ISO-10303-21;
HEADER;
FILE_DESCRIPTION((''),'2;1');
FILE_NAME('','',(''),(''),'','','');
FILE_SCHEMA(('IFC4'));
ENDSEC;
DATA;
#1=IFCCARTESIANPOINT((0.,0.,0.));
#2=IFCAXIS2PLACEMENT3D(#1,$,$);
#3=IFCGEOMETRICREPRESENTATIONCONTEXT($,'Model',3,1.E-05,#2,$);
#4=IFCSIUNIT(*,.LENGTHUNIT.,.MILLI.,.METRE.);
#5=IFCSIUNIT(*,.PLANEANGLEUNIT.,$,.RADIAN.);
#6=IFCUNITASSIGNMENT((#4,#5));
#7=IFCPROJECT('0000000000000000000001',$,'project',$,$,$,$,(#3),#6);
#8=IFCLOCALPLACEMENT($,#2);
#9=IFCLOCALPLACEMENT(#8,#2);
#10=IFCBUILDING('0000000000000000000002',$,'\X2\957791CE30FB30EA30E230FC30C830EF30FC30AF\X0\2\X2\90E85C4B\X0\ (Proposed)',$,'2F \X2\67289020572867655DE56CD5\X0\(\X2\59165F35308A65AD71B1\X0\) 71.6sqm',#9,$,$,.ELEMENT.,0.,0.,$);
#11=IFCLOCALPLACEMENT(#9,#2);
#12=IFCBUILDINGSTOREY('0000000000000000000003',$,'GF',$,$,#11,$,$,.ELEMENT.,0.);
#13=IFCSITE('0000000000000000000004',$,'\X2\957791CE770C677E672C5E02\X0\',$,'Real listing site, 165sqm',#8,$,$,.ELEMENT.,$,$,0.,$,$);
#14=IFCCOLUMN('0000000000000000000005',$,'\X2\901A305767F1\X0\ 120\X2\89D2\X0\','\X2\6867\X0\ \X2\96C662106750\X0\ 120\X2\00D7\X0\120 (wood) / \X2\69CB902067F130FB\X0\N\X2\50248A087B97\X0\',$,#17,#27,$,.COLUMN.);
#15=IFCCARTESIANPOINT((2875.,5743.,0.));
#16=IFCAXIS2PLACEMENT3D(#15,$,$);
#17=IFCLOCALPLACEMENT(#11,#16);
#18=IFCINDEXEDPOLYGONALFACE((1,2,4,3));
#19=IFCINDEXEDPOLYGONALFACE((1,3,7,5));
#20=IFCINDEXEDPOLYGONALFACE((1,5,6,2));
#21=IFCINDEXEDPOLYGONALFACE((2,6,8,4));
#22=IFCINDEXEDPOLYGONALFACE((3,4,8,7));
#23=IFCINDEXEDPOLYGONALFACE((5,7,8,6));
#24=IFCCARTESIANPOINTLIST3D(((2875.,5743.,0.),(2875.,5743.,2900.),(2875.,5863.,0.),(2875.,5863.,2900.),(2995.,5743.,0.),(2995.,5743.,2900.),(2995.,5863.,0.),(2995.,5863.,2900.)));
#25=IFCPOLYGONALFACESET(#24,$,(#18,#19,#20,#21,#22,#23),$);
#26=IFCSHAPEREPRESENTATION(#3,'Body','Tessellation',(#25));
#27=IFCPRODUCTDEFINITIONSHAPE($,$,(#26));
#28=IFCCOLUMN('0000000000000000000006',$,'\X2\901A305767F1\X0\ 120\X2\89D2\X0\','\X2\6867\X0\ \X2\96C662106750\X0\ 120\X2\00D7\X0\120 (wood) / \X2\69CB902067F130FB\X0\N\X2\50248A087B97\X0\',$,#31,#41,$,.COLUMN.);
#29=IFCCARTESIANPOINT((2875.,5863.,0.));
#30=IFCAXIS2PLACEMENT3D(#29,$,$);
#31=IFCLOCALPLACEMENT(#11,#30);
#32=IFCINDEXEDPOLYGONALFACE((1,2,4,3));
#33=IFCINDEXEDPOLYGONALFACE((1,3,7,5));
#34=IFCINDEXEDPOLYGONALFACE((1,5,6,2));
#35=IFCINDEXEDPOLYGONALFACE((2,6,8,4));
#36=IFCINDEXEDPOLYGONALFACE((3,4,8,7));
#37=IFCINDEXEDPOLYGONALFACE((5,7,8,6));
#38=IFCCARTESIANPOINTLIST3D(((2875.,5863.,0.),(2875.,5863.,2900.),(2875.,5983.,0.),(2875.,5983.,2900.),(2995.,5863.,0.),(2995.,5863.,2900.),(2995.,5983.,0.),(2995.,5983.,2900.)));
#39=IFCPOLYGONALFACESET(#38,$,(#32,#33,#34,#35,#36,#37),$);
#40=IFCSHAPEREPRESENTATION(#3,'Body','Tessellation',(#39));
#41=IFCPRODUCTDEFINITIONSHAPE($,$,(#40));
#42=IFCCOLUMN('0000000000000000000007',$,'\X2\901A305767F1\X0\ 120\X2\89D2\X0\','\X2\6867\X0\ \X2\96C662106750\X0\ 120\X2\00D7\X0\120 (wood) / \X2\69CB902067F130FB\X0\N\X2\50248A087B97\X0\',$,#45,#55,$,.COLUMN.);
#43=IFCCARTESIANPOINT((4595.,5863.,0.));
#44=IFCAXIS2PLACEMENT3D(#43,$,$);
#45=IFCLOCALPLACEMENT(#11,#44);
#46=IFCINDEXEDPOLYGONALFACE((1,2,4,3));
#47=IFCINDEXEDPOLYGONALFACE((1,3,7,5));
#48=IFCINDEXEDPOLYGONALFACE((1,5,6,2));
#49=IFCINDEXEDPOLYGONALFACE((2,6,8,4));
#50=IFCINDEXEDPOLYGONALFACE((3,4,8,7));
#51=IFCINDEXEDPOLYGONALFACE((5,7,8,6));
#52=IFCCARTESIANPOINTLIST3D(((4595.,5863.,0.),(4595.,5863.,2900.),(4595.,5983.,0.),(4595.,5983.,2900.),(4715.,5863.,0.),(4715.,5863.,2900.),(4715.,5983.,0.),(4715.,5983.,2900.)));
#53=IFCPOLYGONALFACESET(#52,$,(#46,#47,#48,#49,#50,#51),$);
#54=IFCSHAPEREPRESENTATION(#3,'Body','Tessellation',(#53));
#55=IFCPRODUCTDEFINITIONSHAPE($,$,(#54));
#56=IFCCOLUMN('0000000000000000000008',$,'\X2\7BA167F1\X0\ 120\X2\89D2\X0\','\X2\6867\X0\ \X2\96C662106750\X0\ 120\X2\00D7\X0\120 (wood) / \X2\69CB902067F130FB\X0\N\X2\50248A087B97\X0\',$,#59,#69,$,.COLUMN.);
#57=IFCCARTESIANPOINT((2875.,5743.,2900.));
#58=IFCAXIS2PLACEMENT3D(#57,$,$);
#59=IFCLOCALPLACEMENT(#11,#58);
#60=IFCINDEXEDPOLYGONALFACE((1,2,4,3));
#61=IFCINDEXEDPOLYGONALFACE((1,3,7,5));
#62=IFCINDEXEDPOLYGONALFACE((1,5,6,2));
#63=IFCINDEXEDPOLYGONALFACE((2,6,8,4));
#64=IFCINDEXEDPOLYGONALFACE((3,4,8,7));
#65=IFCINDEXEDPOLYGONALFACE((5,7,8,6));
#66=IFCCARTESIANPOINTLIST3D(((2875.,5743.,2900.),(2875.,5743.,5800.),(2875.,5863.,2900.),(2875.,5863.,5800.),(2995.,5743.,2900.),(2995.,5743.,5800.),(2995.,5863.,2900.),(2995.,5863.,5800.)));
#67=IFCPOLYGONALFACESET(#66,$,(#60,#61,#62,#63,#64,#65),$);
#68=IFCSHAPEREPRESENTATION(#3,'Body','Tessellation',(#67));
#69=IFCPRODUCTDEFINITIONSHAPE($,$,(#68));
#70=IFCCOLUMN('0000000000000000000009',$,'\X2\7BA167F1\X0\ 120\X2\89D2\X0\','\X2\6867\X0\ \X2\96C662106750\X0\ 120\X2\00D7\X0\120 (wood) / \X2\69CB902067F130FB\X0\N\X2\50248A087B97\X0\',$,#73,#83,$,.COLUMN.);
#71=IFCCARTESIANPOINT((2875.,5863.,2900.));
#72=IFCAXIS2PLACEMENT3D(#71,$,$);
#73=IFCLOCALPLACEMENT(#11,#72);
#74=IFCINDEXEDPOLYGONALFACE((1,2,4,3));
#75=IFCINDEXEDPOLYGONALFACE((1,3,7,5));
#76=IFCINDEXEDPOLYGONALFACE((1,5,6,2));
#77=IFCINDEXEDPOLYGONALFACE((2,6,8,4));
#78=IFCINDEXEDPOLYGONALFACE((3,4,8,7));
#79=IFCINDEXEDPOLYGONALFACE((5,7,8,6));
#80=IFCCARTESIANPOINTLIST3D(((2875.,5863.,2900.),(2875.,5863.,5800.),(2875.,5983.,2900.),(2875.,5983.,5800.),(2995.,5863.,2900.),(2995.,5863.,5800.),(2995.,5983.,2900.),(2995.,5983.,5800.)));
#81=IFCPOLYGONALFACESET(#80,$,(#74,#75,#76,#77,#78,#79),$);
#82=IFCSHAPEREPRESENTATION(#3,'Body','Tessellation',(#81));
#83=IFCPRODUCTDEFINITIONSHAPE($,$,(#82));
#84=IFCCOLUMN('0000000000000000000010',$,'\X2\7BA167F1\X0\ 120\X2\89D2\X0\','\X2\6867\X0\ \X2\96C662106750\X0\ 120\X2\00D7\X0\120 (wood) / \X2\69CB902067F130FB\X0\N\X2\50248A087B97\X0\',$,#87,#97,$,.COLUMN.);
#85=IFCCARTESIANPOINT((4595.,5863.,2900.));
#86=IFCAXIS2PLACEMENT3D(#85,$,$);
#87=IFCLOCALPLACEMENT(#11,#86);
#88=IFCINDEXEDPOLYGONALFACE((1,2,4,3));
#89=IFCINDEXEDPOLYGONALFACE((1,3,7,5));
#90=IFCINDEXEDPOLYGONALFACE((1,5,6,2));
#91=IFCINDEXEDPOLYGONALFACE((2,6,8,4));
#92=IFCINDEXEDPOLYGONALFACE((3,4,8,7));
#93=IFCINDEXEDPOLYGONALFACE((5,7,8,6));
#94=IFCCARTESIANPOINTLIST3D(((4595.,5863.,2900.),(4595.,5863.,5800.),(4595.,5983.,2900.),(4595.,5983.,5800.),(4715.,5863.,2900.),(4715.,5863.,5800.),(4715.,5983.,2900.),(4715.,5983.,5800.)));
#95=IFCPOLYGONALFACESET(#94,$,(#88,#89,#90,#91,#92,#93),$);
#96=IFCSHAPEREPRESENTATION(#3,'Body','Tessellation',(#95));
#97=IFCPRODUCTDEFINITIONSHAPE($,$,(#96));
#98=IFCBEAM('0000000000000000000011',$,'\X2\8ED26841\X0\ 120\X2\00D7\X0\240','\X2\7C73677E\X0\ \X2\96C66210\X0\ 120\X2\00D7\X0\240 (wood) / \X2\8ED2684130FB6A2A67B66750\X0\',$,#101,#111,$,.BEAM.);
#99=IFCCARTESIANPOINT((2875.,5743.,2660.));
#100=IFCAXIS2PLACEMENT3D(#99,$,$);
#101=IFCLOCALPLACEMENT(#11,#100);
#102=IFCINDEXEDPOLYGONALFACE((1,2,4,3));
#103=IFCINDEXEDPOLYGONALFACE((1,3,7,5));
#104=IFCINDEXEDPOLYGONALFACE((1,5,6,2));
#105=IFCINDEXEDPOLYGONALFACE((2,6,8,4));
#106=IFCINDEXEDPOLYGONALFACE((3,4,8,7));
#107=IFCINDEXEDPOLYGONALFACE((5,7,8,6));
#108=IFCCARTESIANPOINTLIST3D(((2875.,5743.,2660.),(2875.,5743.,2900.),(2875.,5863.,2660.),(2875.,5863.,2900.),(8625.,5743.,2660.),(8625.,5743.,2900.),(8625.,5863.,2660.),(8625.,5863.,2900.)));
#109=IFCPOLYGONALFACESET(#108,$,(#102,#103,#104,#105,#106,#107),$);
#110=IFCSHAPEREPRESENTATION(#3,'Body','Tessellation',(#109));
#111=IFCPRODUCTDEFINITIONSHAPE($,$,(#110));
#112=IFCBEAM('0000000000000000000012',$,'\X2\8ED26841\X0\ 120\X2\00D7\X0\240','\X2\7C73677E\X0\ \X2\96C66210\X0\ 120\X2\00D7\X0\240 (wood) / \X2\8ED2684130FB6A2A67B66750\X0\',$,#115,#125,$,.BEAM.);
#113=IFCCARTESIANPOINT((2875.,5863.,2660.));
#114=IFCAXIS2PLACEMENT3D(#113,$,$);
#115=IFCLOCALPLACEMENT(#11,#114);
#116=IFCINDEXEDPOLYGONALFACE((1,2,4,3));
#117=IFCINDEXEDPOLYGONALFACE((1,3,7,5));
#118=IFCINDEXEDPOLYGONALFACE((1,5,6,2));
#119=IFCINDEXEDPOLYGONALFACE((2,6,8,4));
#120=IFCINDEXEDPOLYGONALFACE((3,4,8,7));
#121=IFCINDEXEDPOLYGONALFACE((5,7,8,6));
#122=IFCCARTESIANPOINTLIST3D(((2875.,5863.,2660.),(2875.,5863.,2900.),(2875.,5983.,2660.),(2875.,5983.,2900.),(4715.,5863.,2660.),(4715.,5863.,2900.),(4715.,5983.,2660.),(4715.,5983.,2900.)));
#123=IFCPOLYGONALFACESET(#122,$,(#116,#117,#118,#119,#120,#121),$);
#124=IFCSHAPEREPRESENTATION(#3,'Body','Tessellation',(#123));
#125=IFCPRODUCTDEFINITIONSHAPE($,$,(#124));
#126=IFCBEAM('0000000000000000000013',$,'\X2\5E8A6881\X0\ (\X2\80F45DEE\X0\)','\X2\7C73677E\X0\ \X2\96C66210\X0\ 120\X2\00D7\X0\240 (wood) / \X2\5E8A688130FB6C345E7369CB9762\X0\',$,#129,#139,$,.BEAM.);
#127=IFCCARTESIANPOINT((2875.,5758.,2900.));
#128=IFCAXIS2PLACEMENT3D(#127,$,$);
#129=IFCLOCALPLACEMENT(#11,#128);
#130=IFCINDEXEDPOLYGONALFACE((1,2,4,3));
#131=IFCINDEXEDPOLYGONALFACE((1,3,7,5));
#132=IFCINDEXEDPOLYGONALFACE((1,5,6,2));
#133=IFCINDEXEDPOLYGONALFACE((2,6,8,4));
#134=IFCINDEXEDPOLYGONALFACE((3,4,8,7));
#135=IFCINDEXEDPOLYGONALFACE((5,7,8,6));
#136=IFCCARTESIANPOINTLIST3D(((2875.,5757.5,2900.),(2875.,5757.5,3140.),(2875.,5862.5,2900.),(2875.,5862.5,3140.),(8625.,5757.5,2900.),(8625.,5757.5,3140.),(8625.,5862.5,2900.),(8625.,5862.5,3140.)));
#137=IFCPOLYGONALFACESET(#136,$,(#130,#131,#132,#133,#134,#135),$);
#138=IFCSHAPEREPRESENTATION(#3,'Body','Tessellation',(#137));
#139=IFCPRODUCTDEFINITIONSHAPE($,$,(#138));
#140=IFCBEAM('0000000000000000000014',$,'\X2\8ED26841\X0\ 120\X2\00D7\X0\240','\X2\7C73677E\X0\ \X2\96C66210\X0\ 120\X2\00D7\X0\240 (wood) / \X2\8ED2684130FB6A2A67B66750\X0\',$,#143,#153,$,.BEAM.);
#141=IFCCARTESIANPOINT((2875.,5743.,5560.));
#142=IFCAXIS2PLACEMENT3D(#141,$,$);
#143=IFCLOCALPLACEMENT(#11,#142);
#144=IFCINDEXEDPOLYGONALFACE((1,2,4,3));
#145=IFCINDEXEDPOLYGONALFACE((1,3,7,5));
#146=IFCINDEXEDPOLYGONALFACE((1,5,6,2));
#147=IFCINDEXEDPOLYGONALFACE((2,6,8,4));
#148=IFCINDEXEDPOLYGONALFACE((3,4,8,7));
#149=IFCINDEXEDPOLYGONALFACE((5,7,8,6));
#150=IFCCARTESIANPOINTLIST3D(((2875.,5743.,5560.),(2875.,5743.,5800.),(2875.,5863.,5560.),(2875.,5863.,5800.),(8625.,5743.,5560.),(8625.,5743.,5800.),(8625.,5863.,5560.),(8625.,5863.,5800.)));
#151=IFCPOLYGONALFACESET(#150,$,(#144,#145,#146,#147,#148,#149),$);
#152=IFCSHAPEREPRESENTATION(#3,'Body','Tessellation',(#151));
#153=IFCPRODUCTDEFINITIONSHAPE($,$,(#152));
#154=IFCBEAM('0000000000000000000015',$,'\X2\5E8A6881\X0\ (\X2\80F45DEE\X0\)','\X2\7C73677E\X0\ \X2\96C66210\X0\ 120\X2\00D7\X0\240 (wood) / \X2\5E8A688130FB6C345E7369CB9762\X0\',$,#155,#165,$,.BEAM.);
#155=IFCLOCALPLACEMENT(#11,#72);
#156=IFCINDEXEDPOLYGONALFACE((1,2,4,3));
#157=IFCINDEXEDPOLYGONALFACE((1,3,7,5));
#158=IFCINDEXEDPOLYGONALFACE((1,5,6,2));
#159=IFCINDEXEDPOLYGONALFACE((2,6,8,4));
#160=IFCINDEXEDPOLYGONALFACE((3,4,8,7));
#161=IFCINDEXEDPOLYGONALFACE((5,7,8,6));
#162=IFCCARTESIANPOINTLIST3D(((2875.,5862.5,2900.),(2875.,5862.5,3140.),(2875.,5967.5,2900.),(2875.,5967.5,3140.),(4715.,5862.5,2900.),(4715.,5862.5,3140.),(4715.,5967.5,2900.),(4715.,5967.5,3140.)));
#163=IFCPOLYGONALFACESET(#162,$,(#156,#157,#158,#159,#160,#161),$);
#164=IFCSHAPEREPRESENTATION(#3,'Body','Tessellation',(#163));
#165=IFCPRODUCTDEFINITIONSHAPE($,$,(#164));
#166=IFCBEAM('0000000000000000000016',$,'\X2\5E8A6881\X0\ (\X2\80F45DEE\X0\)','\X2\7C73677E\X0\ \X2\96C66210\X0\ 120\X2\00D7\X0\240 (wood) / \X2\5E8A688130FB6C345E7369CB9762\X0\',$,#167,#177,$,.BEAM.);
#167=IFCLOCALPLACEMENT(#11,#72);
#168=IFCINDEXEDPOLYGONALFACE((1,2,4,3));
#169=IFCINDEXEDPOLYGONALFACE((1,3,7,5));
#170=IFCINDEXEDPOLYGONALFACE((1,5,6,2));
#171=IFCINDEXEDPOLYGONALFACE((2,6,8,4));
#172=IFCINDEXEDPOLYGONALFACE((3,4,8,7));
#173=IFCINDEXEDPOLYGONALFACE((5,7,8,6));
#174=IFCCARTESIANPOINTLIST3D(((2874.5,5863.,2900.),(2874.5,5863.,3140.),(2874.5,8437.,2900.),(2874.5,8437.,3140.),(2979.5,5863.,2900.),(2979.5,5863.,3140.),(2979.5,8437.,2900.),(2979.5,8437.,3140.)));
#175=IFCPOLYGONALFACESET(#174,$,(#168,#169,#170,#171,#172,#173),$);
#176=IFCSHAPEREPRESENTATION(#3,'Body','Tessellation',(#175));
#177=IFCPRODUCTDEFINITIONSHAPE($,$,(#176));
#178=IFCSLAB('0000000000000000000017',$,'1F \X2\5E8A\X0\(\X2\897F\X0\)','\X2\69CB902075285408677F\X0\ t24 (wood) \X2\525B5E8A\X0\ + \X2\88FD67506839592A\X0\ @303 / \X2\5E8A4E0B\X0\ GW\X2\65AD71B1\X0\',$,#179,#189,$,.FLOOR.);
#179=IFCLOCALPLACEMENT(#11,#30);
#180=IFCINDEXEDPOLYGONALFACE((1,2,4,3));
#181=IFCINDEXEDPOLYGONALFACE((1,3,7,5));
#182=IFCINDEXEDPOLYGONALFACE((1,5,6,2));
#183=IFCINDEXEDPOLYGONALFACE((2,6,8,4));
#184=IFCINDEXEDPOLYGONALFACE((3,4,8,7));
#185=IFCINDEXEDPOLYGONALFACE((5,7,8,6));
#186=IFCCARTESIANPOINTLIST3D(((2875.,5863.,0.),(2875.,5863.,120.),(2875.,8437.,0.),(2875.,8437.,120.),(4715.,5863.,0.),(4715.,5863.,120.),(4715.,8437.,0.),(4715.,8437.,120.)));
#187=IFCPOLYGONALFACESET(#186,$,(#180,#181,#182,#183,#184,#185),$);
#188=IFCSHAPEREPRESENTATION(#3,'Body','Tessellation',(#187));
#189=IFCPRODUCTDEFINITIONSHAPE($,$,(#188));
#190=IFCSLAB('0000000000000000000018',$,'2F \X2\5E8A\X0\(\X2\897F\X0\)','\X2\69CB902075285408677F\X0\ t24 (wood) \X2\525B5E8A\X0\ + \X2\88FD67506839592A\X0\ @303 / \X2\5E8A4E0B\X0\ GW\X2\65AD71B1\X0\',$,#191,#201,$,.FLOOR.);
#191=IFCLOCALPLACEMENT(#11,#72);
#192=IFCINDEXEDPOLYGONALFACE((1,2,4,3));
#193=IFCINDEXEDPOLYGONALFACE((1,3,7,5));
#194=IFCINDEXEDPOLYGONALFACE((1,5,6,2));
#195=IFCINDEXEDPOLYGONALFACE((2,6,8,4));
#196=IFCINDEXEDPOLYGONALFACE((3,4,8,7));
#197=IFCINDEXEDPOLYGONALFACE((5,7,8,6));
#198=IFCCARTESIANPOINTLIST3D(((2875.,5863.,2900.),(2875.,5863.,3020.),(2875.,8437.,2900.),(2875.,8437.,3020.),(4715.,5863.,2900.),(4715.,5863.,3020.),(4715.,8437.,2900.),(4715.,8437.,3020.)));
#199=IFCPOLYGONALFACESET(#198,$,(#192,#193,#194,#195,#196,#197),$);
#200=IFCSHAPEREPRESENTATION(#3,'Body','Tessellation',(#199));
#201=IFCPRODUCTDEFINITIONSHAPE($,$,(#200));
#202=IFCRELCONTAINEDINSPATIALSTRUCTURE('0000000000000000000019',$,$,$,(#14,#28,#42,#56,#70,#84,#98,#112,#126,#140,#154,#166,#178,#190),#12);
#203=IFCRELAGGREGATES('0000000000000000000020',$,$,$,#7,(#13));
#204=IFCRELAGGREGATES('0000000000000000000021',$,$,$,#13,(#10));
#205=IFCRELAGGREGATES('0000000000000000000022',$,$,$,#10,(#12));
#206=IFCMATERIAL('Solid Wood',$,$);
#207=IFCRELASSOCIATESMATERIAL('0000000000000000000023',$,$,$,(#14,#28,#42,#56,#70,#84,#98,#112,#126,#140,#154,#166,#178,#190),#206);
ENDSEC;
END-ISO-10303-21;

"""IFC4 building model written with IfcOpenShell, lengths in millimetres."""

from ifc_helpers import new_model, si_unit, frame, frame_2d, origin, place, context, project, spatial, rectangle, extrude, material, element, save


model = new_model("IFC4")

# Units and contexts
model_context = context("Model", 3, precision=1e-05, world=origin())
ifc_project = project(units=[si_unit("LENGTHUNIT", "METRE", prefix="MILLI"), si_unit("PLANEANGLEUNIT", "RADIAN")], contexts=[model_context])

# Site, building, storey
site_placement = place(None, origin())
site = spatial("IfcSite", under=ifc_project, at=site_placement, Name="長野県松本市", ObjectType="Real listing site, 165sqm", CompositionType="ELEMENT", RefElevation=0.0)
building_placement = place(site_placement, origin())
building = spatial("IfcBuilding", under=site, at=building_placement, Name="長野・リモートワーク2部屋 (Proposed)", ObjectType="2F 木造在来工法(外張り断熱) 71.6sqm", CompositionType="ELEMENT", ElevationOfRefHeight=0.0, ElevationOfTerrain=0.0)
storey_placement = place(building_placement, origin())
storey = spatial("IfcBuildingStorey", under=building, at=storey_placement, Name="GF", CompositionType="ELEMENT", Elevation=0.0)

# Columns
ifc_material_1 = material(Name="Solid Wood")
column_1_placement = place(storey_placement, frame((2875.0, 5743.0, 0.0)))
element("IfcColumn", 1, at=column_1_placement, inside=storey, material=ifc_material_1, Name="通し柱 120角", Description="桧 集成材 120×120 (wood) / 構造柱・N値計算", PredefinedType="COLUMN", context=model_context, shape_type="SweptSolid", body=[
    extrude(rectangle(XDim=120.0, YDim=120.0, at=frame_2d((60.0, 60.0))), frame((2875.0, 5743.0, 0.0)), (0.0, 0.0, 1.0), 2900.0),
])
column_2_placement = place(storey_placement, frame((2875.0, 5863.0, 0.0)))
element("IfcColumn", 2, at=column_2_placement, inside=storey, material=ifc_material_1, Name="通し柱 120角", Description="桧 集成材 120×120 (wood) / 構造柱・N値計算", PredefinedType="COLUMN", context=model_context, shape_type="SweptSolid", body=[
    extrude(rectangle(XDim=120.0, YDim=120.0, at=frame_2d((60.0, 60.0))), frame((2875.0, 5863.0, 0.0)), (0.0, 0.0, 1.0), 2900.0),
])
column_3_placement = place(storey_placement, frame((4595.0, 5863.0, 0.0)))
element("IfcColumn", 3, at=column_3_placement, inside=storey, material=ifc_material_1, Name="通し柱 120角", Description="桧 集成材 120×120 (wood) / 構造柱・N値計算", PredefinedType="COLUMN", context=model_context, shape_type="SweptSolid", body=[
    extrude(rectangle(XDim=120.0, YDim=120.0, at=frame_2d((60.0, 60.0))), frame((4595.0, 5863.0, 0.0)), (0.0, 0.0, 1.0), 2900.0),
])
column_4_placement = place(storey_placement, frame((2875.0, 5743.0, 2900.0)))
element("IfcColumn", 4, at=column_4_placement, inside=storey, material=ifc_material_1, Name="管柱 120角", Description="桧 集成材 120×120 (wood) / 構造柱・N値計算", PredefinedType="COLUMN", context=model_context, shape_type="SweptSolid", body=[
    extrude(rectangle(XDim=120.0, YDim=120.0, at=frame_2d((60.0, 60.0))), frame((2875.0, 5743.0, 2900.0)), (0.0, 0.0, 1.0), 2900.0),
])
column_5_placement = place(storey_placement, frame((2875.0, 5863.0, 2900.0)))
element("IfcColumn", 5, at=column_5_placement, inside=storey, material=ifc_material_1, Name="管柱 120角", Description="桧 集成材 120×120 (wood) / 構造柱・N値計算", PredefinedType="COLUMN", context=model_context, shape_type="SweptSolid", body=[
    extrude(rectangle(XDim=120.0, YDim=120.0, at=frame_2d((60.0, 60.0))), frame((2875.0, 5863.0, 2900.0)), (0.0, 0.0, 1.0), 2900.0),
])
column_6_placement = place(storey_placement, frame((4595.0, 5863.0, 2900.0)))
element("IfcColumn", 6, at=column_6_placement, inside=storey, material=ifc_material_1, Name="管柱 120角", Description="桧 集成材 120×120 (wood) / 構造柱・N値計算", PredefinedType="COLUMN", context=model_context, shape_type="SweptSolid", body=[
    extrude(rectangle(XDim=120.0, YDim=120.0, at=frame_2d((60.0, 60.0))), frame((4595.0, 5863.0, 2900.0)), (0.0, 0.0, 1.0), 2900.0),
])

# Beams
beam_1_placement = place(storey_placement, frame((2875.0, 5743.0, 2660.0)))
element("IfcBeam", 7, at=beam_1_placement, inside=storey, material=ifc_material_1, Name="軒桁 120×240", Description="米松 集成 120×240 (wood) / 軒桁・横架材", PredefinedType="BEAM", context=model_context, shape_type="SweptSolid", body=[
    extrude(rectangle(XDim=5750.0, YDim=120.0, at=frame_2d((2875.0, 60.0))), frame((2875.0, 5743.0, 2660.0)), (0.0, 0.0, 1.0), 240.0),
])
beam_2_placement = place(storey_placement, frame((2875.0, 5863.0, 2660.0)))
element("IfcBeam", 8, at=beam_2_placement, inside=storey, material=ifc_material_1, Name="軒桁 120×240", Description="米松 集成 120×240 (wood) / 軒桁・横架材", PredefinedType="BEAM", context=model_context, shape_type="SweptSolid", body=[
    extrude(rectangle(XDim=1840.0, YDim=120.0, at=frame_2d((920.0, 60.0))), frame((2875.0, 5863.0, 2660.0)), (0.0, 0.0, 1.0), 240.0),
])
beam_3_placement = place(storey_placement, frame((2875.0, 5758.0, 2900.0)))
element("IfcBeam", 9, at=beam_3_placement, inside=storey, material=ifc_material_1, Name="床梁 (胴差)", Description="米松 集成 120×240 (wood) / 床梁・水平構面", PredefinedType="BEAM", context=model_context, shape_type="SweptSolid", body=[
    extrude(rectangle(XDim=5750.0, YDim=105.0, at=frame_2d((2875.0, 52.0))), frame((2875.0, 5758.0, 2900.0)), (0.0, 0.0, 1.0), 240.0),
])
beam_4_placement = place(storey_placement, frame((2875.0, 5743.0, 5560.0)))
element("IfcBeam", 10, at=beam_4_placement, inside=storey, material=ifc_material_1, Name="軒桁 120×240", Description="米松 集成 120×240 (wood) / 軒桁・横架材", PredefinedType="BEAM", context=model_context, shape_type="SweptSolid", body=[
    extrude(rectangle(XDim=5750.0, YDim=120.0, at=frame_2d((2875.0, 60.0))), frame((2875.0, 5743.0, 5560.0)), (0.0, 0.0, 1.0), 240.0),
])
beam_5_placement = place(storey_placement, frame((2875.0, 5863.0, 2900.0)))
element("IfcBeam", 11, at=beam_5_placement, inside=storey, material=ifc_material_1, Name="床梁 (胴差)", Description="米松 集成 120×240 (wood) / 床梁・水平構面", PredefinedType="BEAM", context=model_context, shape_type="SweptSolid", body=[
    extrude(rectangle(XDim=1840.0, YDim=105.0, at=frame_2d((920.0, 52.0))), frame((2875.0, 5863.0, 2900.0)), (0.0, 0.0, 1.0), 240.0),
])
beam_6_placement = place(storey_placement, frame((2875.0, 5863.0, 2900.0)))
element("IfcBeam", 12, at=beam_6_placement, inside=storey, material=ifc_material_1, Name="床梁 (胴差)", Description="米松 集成 120×240 (wood) / 床梁・水平構面", PredefinedType="BEAM", context=model_context, shape_type="SweptSolid", body=[
    extrude(rectangle(XDim=105.0, YDim=2574.0, at=frame_2d((52.0, 1287.0))), frame((2875.0, 5863.0, 2900.0)), (0.0, 0.0, 1.0), 240.0),
])

# Slabs
slab_1_placement = place(storey_placement, frame((2875.0, 5863.0, 0.0)))
element("IfcSlab", 13, at=slab_1_placement, inside=storey, material=ifc_material_1, Name="1F 床(西)", Description="構造用合板 t24 (wood) 剛床 + 製材根太 @303 / 床下 GW断熱", PredefinedType="FLOOR", context=model_context, shape_type="SweptSolid", body=[
    extrude(rectangle(XDim=1840.0, YDim=2574.0, at=frame_2d((920.0, 1287.0))), frame((2875.0, 5863.0, 0.0)), (0.0, 0.0, 1.0), 120.0),
])
slab_2_placement = place(storey_placement, frame((2875.0, 5863.0, 2900.0)))
element("IfcSlab", 14, at=slab_2_placement, inside=storey, material=ifc_material_1, Name="2F 床(西)", Description="構造用合板 t24 (wood) 剛床 + 製材根太 @303 / 床下 GW断熱", PredefinedType="FLOOR", context=model_context, shape_type="SweptSolid", body=[
    extrude(rectangle(XDim=1840.0, YDim=2574.0, at=frame_2d((920.0, 1287.0))), frame((2875.0, 5863.0, 2900.0)), (0.0, 0.0, 1.0), 120.0),
])

save(model, "model.ifc")
